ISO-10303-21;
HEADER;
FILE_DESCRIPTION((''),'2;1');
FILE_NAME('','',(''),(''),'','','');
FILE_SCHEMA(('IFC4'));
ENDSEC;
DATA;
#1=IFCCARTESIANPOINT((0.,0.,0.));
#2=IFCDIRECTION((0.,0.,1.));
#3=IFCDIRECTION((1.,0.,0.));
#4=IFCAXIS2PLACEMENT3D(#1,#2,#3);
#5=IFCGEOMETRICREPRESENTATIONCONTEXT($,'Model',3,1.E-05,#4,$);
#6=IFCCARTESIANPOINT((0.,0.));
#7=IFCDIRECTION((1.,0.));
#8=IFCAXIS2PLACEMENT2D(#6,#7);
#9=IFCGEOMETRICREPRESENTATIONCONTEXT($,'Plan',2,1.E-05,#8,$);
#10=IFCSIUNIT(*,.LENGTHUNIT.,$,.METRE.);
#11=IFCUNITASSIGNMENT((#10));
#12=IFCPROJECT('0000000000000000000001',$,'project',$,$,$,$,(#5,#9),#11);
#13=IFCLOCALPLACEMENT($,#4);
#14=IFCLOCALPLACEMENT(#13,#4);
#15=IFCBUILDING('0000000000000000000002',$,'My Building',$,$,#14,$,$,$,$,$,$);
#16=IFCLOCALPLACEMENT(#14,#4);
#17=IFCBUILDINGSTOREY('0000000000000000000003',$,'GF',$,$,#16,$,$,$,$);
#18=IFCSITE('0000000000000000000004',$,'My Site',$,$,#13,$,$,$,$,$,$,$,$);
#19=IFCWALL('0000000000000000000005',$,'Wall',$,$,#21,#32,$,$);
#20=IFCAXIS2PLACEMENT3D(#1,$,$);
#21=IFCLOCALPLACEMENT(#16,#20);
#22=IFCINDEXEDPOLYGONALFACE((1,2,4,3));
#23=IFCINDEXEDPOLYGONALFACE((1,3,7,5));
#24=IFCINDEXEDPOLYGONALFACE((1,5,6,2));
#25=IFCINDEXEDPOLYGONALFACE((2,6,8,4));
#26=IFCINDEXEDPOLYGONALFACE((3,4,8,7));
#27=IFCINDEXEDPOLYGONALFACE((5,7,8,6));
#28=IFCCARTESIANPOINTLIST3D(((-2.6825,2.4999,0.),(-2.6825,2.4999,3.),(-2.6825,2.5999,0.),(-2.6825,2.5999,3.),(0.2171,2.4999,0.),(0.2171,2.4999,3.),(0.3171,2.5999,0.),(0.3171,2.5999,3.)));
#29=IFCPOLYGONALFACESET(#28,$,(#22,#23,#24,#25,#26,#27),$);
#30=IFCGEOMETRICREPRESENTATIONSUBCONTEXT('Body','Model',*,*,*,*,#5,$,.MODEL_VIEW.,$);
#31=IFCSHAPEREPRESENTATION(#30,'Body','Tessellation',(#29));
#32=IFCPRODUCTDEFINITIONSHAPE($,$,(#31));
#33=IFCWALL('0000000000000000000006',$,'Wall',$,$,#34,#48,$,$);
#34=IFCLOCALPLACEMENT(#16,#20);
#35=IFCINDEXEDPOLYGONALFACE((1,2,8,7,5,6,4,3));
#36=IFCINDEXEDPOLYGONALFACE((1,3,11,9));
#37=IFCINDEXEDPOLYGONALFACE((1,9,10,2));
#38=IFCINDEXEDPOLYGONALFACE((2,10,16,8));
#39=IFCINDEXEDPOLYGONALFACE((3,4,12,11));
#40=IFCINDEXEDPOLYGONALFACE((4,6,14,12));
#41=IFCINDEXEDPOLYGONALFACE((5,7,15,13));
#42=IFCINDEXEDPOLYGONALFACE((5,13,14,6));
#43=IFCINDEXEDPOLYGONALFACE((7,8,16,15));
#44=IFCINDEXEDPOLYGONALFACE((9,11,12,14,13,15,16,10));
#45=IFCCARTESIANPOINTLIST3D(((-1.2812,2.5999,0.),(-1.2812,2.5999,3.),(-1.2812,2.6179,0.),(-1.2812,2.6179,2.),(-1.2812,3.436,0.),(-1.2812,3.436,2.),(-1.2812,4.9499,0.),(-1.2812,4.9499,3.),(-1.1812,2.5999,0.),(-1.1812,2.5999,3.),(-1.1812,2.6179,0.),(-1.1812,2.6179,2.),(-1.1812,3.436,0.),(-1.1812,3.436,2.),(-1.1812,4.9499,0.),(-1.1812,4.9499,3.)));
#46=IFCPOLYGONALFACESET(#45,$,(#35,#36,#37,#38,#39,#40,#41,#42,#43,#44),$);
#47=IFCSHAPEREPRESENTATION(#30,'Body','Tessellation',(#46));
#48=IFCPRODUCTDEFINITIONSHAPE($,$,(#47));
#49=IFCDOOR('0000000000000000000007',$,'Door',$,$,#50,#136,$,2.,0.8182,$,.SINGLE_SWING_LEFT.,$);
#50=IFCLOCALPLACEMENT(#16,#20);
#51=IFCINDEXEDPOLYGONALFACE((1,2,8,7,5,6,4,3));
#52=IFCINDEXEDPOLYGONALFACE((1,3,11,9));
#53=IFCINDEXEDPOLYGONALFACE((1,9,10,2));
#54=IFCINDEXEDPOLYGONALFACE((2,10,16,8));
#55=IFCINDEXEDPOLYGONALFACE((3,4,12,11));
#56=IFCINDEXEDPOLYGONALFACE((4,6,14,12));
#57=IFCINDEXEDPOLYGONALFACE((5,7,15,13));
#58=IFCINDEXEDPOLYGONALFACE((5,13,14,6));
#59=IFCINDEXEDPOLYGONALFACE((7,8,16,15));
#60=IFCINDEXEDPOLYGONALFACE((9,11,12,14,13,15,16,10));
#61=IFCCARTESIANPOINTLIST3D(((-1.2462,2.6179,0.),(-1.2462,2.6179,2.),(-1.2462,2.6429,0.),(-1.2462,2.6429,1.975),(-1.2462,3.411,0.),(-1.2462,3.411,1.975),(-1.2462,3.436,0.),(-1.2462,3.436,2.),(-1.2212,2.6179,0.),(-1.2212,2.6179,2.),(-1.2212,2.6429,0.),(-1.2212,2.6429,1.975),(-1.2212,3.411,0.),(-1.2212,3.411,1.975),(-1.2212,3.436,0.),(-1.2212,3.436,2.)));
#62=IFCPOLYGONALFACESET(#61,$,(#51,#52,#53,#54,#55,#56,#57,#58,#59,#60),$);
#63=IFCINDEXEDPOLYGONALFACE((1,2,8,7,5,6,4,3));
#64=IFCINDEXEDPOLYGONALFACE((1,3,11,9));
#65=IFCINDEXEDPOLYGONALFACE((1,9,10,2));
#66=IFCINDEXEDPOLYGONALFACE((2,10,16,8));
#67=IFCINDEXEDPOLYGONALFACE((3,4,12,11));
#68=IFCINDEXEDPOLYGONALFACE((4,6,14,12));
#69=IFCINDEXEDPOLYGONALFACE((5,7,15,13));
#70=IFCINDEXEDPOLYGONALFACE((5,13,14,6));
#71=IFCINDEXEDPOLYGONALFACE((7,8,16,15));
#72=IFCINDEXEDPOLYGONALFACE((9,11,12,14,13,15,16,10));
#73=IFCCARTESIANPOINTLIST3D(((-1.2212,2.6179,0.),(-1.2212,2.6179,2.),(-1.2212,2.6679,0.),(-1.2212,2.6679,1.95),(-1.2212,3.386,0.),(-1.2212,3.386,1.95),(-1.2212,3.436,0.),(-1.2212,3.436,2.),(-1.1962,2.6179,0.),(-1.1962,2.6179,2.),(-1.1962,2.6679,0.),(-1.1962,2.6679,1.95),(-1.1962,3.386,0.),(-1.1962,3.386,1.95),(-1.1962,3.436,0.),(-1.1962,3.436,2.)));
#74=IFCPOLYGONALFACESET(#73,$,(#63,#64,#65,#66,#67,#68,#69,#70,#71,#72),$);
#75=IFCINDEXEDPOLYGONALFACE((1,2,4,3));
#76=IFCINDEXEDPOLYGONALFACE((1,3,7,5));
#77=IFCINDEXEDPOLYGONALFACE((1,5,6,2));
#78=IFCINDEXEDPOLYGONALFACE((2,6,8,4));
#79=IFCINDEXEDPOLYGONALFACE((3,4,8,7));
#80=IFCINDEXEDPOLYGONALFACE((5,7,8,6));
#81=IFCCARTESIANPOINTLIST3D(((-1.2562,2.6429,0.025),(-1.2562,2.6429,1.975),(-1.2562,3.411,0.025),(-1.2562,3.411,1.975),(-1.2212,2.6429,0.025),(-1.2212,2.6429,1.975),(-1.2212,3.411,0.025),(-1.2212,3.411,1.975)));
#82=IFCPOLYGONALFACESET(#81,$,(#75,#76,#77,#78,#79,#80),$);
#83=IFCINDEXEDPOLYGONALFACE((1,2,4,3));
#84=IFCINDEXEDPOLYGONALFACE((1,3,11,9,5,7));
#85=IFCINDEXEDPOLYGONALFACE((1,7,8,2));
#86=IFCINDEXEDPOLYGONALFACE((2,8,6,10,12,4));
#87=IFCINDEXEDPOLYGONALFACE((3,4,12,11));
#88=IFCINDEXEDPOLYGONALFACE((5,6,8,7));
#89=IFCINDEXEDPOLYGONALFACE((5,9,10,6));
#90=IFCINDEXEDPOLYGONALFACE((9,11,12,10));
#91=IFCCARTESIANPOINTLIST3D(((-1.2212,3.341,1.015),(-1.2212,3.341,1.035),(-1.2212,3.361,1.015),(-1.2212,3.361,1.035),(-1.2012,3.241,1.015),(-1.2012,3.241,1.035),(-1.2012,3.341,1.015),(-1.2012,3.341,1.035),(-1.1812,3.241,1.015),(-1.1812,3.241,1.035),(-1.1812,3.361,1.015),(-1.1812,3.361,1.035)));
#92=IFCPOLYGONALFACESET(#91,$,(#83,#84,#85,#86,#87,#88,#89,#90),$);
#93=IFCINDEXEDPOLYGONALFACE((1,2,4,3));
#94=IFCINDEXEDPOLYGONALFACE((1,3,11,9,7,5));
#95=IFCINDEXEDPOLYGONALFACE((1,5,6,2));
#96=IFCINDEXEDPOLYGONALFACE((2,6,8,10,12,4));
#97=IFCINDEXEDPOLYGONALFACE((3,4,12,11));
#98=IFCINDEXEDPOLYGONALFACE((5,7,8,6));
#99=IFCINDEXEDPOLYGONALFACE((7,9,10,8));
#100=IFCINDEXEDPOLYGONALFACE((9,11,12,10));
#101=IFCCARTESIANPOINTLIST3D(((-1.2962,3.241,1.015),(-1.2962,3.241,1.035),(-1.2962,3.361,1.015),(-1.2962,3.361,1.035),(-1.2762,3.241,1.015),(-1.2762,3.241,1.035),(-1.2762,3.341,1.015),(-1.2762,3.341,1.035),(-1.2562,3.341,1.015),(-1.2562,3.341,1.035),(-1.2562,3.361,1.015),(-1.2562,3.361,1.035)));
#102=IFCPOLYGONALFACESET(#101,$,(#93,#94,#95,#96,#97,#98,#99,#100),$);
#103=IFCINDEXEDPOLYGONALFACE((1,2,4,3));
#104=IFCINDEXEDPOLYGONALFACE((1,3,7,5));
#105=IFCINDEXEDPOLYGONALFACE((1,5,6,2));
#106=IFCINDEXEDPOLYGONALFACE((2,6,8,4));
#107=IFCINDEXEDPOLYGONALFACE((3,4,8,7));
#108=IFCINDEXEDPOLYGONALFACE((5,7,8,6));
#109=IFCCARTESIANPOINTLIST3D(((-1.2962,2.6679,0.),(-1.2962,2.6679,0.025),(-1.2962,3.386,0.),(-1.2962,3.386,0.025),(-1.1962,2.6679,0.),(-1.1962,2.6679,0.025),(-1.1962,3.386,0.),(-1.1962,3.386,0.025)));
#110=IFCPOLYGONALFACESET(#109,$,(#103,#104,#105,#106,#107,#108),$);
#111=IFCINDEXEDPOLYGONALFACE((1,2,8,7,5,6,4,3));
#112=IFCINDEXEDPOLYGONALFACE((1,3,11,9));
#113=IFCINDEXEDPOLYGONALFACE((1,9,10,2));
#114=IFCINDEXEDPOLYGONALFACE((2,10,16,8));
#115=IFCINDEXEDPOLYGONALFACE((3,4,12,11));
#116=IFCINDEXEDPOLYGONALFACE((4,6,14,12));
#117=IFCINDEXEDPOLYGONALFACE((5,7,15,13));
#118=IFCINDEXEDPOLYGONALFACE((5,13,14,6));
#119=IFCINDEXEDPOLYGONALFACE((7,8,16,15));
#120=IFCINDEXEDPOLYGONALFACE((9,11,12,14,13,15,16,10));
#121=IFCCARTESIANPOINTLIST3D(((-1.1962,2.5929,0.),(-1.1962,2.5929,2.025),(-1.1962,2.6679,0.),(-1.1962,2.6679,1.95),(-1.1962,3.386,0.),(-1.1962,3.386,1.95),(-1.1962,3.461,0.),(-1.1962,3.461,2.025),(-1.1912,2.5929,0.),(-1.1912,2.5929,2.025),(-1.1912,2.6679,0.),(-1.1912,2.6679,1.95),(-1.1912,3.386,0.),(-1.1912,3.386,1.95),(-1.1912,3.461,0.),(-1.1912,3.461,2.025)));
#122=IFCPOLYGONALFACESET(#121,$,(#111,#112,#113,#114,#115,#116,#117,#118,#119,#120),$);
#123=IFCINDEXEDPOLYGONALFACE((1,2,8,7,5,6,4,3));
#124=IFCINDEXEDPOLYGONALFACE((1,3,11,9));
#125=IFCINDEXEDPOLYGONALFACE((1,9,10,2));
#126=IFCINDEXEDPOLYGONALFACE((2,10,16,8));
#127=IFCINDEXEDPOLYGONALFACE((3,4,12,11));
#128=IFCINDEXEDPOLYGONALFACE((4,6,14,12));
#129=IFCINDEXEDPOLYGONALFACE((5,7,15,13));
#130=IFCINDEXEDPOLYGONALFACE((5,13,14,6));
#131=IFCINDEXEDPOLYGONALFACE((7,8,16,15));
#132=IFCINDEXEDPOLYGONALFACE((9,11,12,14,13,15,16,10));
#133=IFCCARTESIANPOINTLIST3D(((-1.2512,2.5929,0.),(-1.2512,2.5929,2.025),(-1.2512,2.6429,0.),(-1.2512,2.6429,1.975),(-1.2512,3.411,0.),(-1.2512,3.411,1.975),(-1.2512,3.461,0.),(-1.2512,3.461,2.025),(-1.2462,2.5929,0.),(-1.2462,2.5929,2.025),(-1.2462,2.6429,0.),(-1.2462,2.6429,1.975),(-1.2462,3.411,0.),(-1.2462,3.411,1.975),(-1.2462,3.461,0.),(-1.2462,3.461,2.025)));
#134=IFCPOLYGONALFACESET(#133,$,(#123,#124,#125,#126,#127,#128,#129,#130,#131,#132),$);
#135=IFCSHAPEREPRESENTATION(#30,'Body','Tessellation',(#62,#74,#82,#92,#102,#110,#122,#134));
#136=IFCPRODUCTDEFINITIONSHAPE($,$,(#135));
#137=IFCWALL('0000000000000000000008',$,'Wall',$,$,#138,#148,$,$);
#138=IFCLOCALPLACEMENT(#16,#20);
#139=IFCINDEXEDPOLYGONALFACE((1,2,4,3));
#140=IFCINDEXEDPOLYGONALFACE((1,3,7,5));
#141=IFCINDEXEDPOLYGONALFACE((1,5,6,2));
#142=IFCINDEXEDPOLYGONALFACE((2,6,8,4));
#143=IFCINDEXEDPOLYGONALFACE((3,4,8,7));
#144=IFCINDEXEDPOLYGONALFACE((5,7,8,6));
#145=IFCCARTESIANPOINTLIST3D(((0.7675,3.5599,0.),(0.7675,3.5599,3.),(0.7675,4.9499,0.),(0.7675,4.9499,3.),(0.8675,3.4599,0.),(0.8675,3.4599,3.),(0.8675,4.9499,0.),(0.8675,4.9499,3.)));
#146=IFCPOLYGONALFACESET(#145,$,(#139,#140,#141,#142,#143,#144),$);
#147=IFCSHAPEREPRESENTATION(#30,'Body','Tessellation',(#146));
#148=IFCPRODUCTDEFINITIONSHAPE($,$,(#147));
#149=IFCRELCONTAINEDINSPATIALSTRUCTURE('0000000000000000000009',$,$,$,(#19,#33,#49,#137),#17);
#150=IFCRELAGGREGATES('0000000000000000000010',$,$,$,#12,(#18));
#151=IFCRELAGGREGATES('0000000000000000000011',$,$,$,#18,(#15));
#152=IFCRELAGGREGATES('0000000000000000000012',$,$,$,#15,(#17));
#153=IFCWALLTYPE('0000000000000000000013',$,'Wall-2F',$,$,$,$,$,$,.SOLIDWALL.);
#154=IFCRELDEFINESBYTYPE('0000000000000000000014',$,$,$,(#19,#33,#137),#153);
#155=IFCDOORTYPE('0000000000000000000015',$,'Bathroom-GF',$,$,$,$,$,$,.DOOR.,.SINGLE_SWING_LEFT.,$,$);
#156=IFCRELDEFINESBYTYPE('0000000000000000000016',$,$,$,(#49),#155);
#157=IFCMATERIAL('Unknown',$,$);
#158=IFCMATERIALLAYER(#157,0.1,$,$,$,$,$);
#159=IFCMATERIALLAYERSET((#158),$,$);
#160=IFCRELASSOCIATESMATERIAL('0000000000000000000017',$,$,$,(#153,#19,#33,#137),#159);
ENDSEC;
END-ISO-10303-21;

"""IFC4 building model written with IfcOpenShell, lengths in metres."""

from ifc_helpers import new_model, entity, si_unit, frame, origin_with_axes, origin_2d_with_axis, place, context, subcontext, project, spatial, line, indexed_curve, outline, extrude, shape, source, transform, mapped, material, layer, layer_set, layer_usage, type_object, type_shapes, element, fill, save


model = new_model("IFC4")

# Units and contexts
model_context = context("Model", 3, precision=1e-05, world=origin_with_axes())
plan_context = context("Plan", 2, precision=1e-05, world=origin_2d_with_axis())
body_context_1 = subcontext(model_context, "Body", "Model", "MODEL_VIEW")
body_context_2 = subcontext(plan_context, "Body", "Plan", "PLAN_VIEW")
ifc_project = project(units=[si_unit("LENGTHUNIT", "METRE")], contexts=[model_context, plan_context])

# Site, building, storey
site_placement = place(None, origin_with_axes())
site = spatial("IfcSite", under=ifc_project, at=site_placement, Name="My Site")
building_placement = place(site_placement, origin_with_axes())
building = spatial("IfcBuilding", under=site, at=building_placement, Name="My Building")
storey_placement = place(building_placement, origin_with_axes())
storey = spatial("IfcBuildingStorey", under=building, at=storey_placement, Name="GF")

# Shared definitions
ifc_material_1 = material(Name="Unknown")

# Shared definitions
ifc_layer_1 = layer(ifc_material_1, 0.1)
ifc_layer_set_1 = layer_set([ifc_layer_1])
wall_type = type_object("IfcWallType", Name="Wall-2F", PredefinedType="SOLIDWALL", material=ifc_layer_set_1)

# Wall
ifc_layer_usage_1 = layer_usage(ifc_layer_set_1, "AXIS2", "POSITIVE", 0.0)
wall_1_placement = place(storey_placement, frame((0.3171, 2.5999, 0.0), z_axis=(0.0, 0.0, 1.0), x_axis=(-1.0, 0.0, 0.0)))
element("IfcWall", 1, at=wall_1_placement, inside=storey, type_object=wall_type, material=ifc_layer_usage_1, Name="Wall", context=body_context_1, shape_type="SweptSolid", body=[
    extrude(outline(indexed_curve([(0.0, 0.0), (0.1, 0.1), (2.9996, 0.1), (2.9996, 0.0)], segments=[line(1, 2, 3, 4, 1)])), origin_with_axes(), (0.0, 0.0, 1.0), 3.0),
])

# Wall, opening, door
ifc_layer_usage_2 = layer_usage(ifc_layer_set_1, "AXIS2", "POSITIVE", 0.0)
wall_2_placement = place(storey_placement, frame((-1.1812, 2.5999, 0.0), z_axis=(0.0, 0.0, 1.0), x_axis=(0.0, 1.0, 0.0)))
wall_2 = element("IfcWall", 2, at=wall_2_placement, inside=storey, type_object=wall_type, material=ifc_layer_usage_2, Name="Wall", context=body_context_1, shape_type="SweptSolid", body=[
    extrude(outline(indexed_curve([(0.0, 0.0), (0.0, 0.1), (2.35, 0.1), (2.35, 0.0)], segments=[line(1, 2, 3, 4, 1)])), origin_with_axes(), (0.0, 0.0, 1.0), 3.0),
])
shared_shape_1 = source(origin_with_axes(), body_context_1, "Body", "SweptSolid", [
    extrude(outline(indexed_curve([(0.0, 0.0), (0.8182, 0.0), (0.8182, 2.0), (0.0, 2.0)], segments=[line(1, 2, 3, 4, 1)])), frame((0.0, -0.6, 0.0), z_axis=(0.0, -1.0, 0.0), x_axis=(1.0, 0.0, 0.0)), (0.0, 0.0, -1.0), 1.2),
])
opening_1_placement = place(wall_2_placement, frame((0.0179, 0.015, 0.0), z_axis=(0.0, 0.0, 1.0), x_axis=(1.0, 0.0, 0.0)))
opening_1 = element("IfcOpeningElement", 3, at=opening_1_placement, cuts=wall_2, PredefinedType="OPENING", context=body_context_1, shape_type="MappedRepresentation", body=[
    mapped(shared_shape_1, transform((0.0, 0.0, 0.0), x_axis=(1.0, 0.0, 0.0), y_axis=(0.0, 1.0, 0.0), z_axis=(0.0, 0.0, 1.0), scale=1.0)),
])
door_type_1 = type_object("IfcDoorType", Name="Bathroom-GF", OperationType="SINGLE_SWING_LEFT", PredefinedType="DOOR")
shared_shape_2 = source(origin_with_axes(), body_context_1, "Body", "SweptSolid", [
    extrude(outline(indexed_curve([(0.0, 0.0), (0.0, 2.0), (0.8182, 2.0), (0.8182, 0.0), (0.7932, 0.0), (0.7932, 1.975), (0.025, 1.975), (0.025, 0.0)], segments=[line(1, 2, 3, 4, 5, 6, 7, 8, 1)])), frame((0.0, 0.025, 0.0), z_axis=(0.0, -1.0, 0.0), x_axis=(1.0, 0.0, 0.0)), (0.0, 0.0, -1.0), 0.025),
    extrude(outline(indexed_curve([(0.0, 0.0), (0.0, 2.0), (0.8182, 2.0), (0.8182, 0.0), (0.7682, 0.0), (0.7682, 1.95), (0.05, 1.95), (0.05, 0.0)], segments=[line(1, 2, 3, 4, 5, 6, 7, 8, 1)])), frame((0.0, 0.0, 0.0), z_axis=(0.0, -1.0, 0.0), x_axis=(1.0, 0.0, 0.0)), (0.0, 0.0, -1.0), 0.025),
    extrude(outline(indexed_curve([(0.0, 0.0), (0.7682, 0.0), (0.7682, 0.035), (0.0, 0.035)], segments=[line(1, 2, 3, 4, 1)])), frame((0.025, 0.025, 0.025), z_axis=(0.0, 0.0, 1.0), x_axis=(1.0, 0.0, 0.0)), (0.0, 0.0, 1.0), 1.95),
    extrude(outline(indexed_curve([(0.0, 0.0), (0.0, -0.04), (-0.12, -0.04), (-0.12, -0.02), (-0.02, -0.02), (-0.02, 0.0)], segments=[line(1, 2, 3, 4, 5, 6, 1)])), frame((0.7432, 0.025, 1.015), z_axis=(0.0, 0.0, 1.0), x_axis=(1.0, 0.0, 0.0)), (0.0, 0.0, 1.0), 0.02),
    extrude(outline(indexed_curve([(0.0, 0.0), (0.0, 0.04), (-0.12, 0.04), (-0.12, 0.02), (-0.02, 0.02), (-0.02, 0.0)], segments=[line(1, 2, 3, 4, 5, 6, 1)])), frame((0.7432, 0.06, 1.015), z_axis=(0.0, 0.0, 1.0), x_axis=(1.0, 0.0, 0.0)), (0.0, 0.0, 1.0), 0.02),
    extrude(outline(indexed_curve([(0.0, 0.0), (0.7182, 0.0), (0.7182, 0.1), (0.0, 0.1)], segments=[line(1, 2, 3, 4, 1)])), frame((0.05, 0.0, 0.0), z_axis=(0.0, 0.0, 1.0), x_axis=(1.0, 0.0, 0.0)), (0.0, 0.0, 1.0), 0.025),
    extrude(outline(indexed_curve([(0.0, 0.0), (0.0, 2.025), (0.8682, 2.025), (0.8682, 0.0), (0.7932, 0.0), (0.7932, 1.95), (0.075, 1.95), (0.075, 0.0)], segments=[line(1, 2, 3, 4, 5, 6, 7, 8, 1)])), frame((-0.025, -0.005, 0.0), z_axis=(0.0, -1.0, 0.0), x_axis=(1.0, 0.0, 0.0)), (0.0, 0.0, -1.0), 0.005),
    extrude(outline(indexed_curve([(0.0, 0.0), (0.0, 2.025), (0.8682, 2.025), (0.8682, 0.0), (0.8182, 0.0), (0.8182, 1.975), (0.05, 1.975), (0.05, 0.0)], segments=[line(1, 2, 3, 4, 5, 6, 7, 8, 1)])), frame((-0.025, 0.05, 0.0), z_axis=(0.0, -1.0, 0.0), x_axis=(1.0, 0.0, 0.0)), (0.0, 0.0, -1.0), 0.005),
])
shared_shape_3 = source(origin_with_axes(), body_context_2, "Body", "Curve2D", [
    entity("IfcIndexedPolyCurve", entity("IfcCartesianPointList2D", [[0.0, 0.0], [0.0, 0.05], [0.025, 0.05], [0.025, 0.025], [0.05, 0.025], [0.05, 0.0]]), [entity("IfcLineIndex", [1, 2, 3, 4, 5, 6, 1])]),
    entity("IfcIndexedPolyCurve", entity("IfcCartesianPointList2D", [[0.8182, 0.0], [0.8182, 0.05], [0.7932, 0.05], [0.7932, 0.025], [0.7682, 0.025], [0.7682, 0.0]]), [entity("IfcLineIndex", [1, 2, 3, 4, 5, 6, 1])]),
    entity("IfcTrimmedCurve", entity("IfcEllipse", entity("IfcAxis2Placement2D", entity("IfcCartesianPoint", [0.06, 0.05]), entity("IfcDirection", [1.0, 0.0])), 0.7332, 0.7682), [entity("IfcCartesianPoint", [0.7932, 0.05])], [entity("IfcCartesianPoint", [0.06, 0.8182])], True, "CARTESIAN"),
    entity("IfcIndexedPolyCurve", entity("IfcCartesianPointList2D", [[0.025, 0.05], [0.06, 0.05], [0.06, 0.8182], [0.025, 0.8182]]), [entity("IfcLineIndex", [1, 2, 3, 4, 1])]),
])
type_shapes(door_type_1, [shared_shape_2, shared_shape_3])
door_1_placement = place(opening_1_placement, frame((0.0, 0.0, 0.0), z_axis=(0.0, 0.0, 1.0), x_axis=(1.0, 0.0, 0.0)))
door_1 = element("IfcDoor", 4, at=door_1_placement, inside=storey, type_object=door_type_1, Name="Door", OperationType="SINGLE_SWING_LEFT", OverallHeight=2.0, OverallWidth=0.8182, shapes=[
    shape(body_context_1, "Body", "MappedRepresentation", [mapped(shared_shape_2, transform((0.0, 0.0, 0.0), x_axis=(1.0, 0.0, 0.0), y_axis=(0.0, 1.0, 0.0), z_axis=(0.0, 0.0, 1.0), scale=1.0))]),
    shape(body_context_2, "Body", "MappedRepresentation", [mapped(shared_shape_3, transform((0.0, 0.0, 0.0), x_axis=(1.0, 0.0, 0.0), y_axis=(0.0, 1.0, 0.0), z_axis=(0.0, 0.0, 1.0), scale=1.0))]),
])
fill(opening_1, door_1)

# Wall
ifc_layer_usage_3 = layer_usage(ifc_layer_set_1, "AXIS2", "POSITIVE", 0.0)
wall_3_placement = place(storey_placement, frame((0.7675, 5.0499, 0.0), z_axis=(0.0, 0.0, 1.0), x_axis=(0.0, -1.0, 0.0)))
element("IfcWall", 5, at=wall_3_placement, inside=storey, type_object=wall_type, material=ifc_layer_usage_3, Name="Wall", context=body_context_1, shape_type="SweptSolid", body=[
    extrude(outline(indexed_curve([(0.1, 0.0), (0.1, 0.1), (1.59, 0.1), (1.49, 0.0)], segments=[line(1, 2, 3, 4, 1)])), origin_with_axes(), (0.0, 0.0, 1.0), 3.0),
])

save(model, "model.ifc")
